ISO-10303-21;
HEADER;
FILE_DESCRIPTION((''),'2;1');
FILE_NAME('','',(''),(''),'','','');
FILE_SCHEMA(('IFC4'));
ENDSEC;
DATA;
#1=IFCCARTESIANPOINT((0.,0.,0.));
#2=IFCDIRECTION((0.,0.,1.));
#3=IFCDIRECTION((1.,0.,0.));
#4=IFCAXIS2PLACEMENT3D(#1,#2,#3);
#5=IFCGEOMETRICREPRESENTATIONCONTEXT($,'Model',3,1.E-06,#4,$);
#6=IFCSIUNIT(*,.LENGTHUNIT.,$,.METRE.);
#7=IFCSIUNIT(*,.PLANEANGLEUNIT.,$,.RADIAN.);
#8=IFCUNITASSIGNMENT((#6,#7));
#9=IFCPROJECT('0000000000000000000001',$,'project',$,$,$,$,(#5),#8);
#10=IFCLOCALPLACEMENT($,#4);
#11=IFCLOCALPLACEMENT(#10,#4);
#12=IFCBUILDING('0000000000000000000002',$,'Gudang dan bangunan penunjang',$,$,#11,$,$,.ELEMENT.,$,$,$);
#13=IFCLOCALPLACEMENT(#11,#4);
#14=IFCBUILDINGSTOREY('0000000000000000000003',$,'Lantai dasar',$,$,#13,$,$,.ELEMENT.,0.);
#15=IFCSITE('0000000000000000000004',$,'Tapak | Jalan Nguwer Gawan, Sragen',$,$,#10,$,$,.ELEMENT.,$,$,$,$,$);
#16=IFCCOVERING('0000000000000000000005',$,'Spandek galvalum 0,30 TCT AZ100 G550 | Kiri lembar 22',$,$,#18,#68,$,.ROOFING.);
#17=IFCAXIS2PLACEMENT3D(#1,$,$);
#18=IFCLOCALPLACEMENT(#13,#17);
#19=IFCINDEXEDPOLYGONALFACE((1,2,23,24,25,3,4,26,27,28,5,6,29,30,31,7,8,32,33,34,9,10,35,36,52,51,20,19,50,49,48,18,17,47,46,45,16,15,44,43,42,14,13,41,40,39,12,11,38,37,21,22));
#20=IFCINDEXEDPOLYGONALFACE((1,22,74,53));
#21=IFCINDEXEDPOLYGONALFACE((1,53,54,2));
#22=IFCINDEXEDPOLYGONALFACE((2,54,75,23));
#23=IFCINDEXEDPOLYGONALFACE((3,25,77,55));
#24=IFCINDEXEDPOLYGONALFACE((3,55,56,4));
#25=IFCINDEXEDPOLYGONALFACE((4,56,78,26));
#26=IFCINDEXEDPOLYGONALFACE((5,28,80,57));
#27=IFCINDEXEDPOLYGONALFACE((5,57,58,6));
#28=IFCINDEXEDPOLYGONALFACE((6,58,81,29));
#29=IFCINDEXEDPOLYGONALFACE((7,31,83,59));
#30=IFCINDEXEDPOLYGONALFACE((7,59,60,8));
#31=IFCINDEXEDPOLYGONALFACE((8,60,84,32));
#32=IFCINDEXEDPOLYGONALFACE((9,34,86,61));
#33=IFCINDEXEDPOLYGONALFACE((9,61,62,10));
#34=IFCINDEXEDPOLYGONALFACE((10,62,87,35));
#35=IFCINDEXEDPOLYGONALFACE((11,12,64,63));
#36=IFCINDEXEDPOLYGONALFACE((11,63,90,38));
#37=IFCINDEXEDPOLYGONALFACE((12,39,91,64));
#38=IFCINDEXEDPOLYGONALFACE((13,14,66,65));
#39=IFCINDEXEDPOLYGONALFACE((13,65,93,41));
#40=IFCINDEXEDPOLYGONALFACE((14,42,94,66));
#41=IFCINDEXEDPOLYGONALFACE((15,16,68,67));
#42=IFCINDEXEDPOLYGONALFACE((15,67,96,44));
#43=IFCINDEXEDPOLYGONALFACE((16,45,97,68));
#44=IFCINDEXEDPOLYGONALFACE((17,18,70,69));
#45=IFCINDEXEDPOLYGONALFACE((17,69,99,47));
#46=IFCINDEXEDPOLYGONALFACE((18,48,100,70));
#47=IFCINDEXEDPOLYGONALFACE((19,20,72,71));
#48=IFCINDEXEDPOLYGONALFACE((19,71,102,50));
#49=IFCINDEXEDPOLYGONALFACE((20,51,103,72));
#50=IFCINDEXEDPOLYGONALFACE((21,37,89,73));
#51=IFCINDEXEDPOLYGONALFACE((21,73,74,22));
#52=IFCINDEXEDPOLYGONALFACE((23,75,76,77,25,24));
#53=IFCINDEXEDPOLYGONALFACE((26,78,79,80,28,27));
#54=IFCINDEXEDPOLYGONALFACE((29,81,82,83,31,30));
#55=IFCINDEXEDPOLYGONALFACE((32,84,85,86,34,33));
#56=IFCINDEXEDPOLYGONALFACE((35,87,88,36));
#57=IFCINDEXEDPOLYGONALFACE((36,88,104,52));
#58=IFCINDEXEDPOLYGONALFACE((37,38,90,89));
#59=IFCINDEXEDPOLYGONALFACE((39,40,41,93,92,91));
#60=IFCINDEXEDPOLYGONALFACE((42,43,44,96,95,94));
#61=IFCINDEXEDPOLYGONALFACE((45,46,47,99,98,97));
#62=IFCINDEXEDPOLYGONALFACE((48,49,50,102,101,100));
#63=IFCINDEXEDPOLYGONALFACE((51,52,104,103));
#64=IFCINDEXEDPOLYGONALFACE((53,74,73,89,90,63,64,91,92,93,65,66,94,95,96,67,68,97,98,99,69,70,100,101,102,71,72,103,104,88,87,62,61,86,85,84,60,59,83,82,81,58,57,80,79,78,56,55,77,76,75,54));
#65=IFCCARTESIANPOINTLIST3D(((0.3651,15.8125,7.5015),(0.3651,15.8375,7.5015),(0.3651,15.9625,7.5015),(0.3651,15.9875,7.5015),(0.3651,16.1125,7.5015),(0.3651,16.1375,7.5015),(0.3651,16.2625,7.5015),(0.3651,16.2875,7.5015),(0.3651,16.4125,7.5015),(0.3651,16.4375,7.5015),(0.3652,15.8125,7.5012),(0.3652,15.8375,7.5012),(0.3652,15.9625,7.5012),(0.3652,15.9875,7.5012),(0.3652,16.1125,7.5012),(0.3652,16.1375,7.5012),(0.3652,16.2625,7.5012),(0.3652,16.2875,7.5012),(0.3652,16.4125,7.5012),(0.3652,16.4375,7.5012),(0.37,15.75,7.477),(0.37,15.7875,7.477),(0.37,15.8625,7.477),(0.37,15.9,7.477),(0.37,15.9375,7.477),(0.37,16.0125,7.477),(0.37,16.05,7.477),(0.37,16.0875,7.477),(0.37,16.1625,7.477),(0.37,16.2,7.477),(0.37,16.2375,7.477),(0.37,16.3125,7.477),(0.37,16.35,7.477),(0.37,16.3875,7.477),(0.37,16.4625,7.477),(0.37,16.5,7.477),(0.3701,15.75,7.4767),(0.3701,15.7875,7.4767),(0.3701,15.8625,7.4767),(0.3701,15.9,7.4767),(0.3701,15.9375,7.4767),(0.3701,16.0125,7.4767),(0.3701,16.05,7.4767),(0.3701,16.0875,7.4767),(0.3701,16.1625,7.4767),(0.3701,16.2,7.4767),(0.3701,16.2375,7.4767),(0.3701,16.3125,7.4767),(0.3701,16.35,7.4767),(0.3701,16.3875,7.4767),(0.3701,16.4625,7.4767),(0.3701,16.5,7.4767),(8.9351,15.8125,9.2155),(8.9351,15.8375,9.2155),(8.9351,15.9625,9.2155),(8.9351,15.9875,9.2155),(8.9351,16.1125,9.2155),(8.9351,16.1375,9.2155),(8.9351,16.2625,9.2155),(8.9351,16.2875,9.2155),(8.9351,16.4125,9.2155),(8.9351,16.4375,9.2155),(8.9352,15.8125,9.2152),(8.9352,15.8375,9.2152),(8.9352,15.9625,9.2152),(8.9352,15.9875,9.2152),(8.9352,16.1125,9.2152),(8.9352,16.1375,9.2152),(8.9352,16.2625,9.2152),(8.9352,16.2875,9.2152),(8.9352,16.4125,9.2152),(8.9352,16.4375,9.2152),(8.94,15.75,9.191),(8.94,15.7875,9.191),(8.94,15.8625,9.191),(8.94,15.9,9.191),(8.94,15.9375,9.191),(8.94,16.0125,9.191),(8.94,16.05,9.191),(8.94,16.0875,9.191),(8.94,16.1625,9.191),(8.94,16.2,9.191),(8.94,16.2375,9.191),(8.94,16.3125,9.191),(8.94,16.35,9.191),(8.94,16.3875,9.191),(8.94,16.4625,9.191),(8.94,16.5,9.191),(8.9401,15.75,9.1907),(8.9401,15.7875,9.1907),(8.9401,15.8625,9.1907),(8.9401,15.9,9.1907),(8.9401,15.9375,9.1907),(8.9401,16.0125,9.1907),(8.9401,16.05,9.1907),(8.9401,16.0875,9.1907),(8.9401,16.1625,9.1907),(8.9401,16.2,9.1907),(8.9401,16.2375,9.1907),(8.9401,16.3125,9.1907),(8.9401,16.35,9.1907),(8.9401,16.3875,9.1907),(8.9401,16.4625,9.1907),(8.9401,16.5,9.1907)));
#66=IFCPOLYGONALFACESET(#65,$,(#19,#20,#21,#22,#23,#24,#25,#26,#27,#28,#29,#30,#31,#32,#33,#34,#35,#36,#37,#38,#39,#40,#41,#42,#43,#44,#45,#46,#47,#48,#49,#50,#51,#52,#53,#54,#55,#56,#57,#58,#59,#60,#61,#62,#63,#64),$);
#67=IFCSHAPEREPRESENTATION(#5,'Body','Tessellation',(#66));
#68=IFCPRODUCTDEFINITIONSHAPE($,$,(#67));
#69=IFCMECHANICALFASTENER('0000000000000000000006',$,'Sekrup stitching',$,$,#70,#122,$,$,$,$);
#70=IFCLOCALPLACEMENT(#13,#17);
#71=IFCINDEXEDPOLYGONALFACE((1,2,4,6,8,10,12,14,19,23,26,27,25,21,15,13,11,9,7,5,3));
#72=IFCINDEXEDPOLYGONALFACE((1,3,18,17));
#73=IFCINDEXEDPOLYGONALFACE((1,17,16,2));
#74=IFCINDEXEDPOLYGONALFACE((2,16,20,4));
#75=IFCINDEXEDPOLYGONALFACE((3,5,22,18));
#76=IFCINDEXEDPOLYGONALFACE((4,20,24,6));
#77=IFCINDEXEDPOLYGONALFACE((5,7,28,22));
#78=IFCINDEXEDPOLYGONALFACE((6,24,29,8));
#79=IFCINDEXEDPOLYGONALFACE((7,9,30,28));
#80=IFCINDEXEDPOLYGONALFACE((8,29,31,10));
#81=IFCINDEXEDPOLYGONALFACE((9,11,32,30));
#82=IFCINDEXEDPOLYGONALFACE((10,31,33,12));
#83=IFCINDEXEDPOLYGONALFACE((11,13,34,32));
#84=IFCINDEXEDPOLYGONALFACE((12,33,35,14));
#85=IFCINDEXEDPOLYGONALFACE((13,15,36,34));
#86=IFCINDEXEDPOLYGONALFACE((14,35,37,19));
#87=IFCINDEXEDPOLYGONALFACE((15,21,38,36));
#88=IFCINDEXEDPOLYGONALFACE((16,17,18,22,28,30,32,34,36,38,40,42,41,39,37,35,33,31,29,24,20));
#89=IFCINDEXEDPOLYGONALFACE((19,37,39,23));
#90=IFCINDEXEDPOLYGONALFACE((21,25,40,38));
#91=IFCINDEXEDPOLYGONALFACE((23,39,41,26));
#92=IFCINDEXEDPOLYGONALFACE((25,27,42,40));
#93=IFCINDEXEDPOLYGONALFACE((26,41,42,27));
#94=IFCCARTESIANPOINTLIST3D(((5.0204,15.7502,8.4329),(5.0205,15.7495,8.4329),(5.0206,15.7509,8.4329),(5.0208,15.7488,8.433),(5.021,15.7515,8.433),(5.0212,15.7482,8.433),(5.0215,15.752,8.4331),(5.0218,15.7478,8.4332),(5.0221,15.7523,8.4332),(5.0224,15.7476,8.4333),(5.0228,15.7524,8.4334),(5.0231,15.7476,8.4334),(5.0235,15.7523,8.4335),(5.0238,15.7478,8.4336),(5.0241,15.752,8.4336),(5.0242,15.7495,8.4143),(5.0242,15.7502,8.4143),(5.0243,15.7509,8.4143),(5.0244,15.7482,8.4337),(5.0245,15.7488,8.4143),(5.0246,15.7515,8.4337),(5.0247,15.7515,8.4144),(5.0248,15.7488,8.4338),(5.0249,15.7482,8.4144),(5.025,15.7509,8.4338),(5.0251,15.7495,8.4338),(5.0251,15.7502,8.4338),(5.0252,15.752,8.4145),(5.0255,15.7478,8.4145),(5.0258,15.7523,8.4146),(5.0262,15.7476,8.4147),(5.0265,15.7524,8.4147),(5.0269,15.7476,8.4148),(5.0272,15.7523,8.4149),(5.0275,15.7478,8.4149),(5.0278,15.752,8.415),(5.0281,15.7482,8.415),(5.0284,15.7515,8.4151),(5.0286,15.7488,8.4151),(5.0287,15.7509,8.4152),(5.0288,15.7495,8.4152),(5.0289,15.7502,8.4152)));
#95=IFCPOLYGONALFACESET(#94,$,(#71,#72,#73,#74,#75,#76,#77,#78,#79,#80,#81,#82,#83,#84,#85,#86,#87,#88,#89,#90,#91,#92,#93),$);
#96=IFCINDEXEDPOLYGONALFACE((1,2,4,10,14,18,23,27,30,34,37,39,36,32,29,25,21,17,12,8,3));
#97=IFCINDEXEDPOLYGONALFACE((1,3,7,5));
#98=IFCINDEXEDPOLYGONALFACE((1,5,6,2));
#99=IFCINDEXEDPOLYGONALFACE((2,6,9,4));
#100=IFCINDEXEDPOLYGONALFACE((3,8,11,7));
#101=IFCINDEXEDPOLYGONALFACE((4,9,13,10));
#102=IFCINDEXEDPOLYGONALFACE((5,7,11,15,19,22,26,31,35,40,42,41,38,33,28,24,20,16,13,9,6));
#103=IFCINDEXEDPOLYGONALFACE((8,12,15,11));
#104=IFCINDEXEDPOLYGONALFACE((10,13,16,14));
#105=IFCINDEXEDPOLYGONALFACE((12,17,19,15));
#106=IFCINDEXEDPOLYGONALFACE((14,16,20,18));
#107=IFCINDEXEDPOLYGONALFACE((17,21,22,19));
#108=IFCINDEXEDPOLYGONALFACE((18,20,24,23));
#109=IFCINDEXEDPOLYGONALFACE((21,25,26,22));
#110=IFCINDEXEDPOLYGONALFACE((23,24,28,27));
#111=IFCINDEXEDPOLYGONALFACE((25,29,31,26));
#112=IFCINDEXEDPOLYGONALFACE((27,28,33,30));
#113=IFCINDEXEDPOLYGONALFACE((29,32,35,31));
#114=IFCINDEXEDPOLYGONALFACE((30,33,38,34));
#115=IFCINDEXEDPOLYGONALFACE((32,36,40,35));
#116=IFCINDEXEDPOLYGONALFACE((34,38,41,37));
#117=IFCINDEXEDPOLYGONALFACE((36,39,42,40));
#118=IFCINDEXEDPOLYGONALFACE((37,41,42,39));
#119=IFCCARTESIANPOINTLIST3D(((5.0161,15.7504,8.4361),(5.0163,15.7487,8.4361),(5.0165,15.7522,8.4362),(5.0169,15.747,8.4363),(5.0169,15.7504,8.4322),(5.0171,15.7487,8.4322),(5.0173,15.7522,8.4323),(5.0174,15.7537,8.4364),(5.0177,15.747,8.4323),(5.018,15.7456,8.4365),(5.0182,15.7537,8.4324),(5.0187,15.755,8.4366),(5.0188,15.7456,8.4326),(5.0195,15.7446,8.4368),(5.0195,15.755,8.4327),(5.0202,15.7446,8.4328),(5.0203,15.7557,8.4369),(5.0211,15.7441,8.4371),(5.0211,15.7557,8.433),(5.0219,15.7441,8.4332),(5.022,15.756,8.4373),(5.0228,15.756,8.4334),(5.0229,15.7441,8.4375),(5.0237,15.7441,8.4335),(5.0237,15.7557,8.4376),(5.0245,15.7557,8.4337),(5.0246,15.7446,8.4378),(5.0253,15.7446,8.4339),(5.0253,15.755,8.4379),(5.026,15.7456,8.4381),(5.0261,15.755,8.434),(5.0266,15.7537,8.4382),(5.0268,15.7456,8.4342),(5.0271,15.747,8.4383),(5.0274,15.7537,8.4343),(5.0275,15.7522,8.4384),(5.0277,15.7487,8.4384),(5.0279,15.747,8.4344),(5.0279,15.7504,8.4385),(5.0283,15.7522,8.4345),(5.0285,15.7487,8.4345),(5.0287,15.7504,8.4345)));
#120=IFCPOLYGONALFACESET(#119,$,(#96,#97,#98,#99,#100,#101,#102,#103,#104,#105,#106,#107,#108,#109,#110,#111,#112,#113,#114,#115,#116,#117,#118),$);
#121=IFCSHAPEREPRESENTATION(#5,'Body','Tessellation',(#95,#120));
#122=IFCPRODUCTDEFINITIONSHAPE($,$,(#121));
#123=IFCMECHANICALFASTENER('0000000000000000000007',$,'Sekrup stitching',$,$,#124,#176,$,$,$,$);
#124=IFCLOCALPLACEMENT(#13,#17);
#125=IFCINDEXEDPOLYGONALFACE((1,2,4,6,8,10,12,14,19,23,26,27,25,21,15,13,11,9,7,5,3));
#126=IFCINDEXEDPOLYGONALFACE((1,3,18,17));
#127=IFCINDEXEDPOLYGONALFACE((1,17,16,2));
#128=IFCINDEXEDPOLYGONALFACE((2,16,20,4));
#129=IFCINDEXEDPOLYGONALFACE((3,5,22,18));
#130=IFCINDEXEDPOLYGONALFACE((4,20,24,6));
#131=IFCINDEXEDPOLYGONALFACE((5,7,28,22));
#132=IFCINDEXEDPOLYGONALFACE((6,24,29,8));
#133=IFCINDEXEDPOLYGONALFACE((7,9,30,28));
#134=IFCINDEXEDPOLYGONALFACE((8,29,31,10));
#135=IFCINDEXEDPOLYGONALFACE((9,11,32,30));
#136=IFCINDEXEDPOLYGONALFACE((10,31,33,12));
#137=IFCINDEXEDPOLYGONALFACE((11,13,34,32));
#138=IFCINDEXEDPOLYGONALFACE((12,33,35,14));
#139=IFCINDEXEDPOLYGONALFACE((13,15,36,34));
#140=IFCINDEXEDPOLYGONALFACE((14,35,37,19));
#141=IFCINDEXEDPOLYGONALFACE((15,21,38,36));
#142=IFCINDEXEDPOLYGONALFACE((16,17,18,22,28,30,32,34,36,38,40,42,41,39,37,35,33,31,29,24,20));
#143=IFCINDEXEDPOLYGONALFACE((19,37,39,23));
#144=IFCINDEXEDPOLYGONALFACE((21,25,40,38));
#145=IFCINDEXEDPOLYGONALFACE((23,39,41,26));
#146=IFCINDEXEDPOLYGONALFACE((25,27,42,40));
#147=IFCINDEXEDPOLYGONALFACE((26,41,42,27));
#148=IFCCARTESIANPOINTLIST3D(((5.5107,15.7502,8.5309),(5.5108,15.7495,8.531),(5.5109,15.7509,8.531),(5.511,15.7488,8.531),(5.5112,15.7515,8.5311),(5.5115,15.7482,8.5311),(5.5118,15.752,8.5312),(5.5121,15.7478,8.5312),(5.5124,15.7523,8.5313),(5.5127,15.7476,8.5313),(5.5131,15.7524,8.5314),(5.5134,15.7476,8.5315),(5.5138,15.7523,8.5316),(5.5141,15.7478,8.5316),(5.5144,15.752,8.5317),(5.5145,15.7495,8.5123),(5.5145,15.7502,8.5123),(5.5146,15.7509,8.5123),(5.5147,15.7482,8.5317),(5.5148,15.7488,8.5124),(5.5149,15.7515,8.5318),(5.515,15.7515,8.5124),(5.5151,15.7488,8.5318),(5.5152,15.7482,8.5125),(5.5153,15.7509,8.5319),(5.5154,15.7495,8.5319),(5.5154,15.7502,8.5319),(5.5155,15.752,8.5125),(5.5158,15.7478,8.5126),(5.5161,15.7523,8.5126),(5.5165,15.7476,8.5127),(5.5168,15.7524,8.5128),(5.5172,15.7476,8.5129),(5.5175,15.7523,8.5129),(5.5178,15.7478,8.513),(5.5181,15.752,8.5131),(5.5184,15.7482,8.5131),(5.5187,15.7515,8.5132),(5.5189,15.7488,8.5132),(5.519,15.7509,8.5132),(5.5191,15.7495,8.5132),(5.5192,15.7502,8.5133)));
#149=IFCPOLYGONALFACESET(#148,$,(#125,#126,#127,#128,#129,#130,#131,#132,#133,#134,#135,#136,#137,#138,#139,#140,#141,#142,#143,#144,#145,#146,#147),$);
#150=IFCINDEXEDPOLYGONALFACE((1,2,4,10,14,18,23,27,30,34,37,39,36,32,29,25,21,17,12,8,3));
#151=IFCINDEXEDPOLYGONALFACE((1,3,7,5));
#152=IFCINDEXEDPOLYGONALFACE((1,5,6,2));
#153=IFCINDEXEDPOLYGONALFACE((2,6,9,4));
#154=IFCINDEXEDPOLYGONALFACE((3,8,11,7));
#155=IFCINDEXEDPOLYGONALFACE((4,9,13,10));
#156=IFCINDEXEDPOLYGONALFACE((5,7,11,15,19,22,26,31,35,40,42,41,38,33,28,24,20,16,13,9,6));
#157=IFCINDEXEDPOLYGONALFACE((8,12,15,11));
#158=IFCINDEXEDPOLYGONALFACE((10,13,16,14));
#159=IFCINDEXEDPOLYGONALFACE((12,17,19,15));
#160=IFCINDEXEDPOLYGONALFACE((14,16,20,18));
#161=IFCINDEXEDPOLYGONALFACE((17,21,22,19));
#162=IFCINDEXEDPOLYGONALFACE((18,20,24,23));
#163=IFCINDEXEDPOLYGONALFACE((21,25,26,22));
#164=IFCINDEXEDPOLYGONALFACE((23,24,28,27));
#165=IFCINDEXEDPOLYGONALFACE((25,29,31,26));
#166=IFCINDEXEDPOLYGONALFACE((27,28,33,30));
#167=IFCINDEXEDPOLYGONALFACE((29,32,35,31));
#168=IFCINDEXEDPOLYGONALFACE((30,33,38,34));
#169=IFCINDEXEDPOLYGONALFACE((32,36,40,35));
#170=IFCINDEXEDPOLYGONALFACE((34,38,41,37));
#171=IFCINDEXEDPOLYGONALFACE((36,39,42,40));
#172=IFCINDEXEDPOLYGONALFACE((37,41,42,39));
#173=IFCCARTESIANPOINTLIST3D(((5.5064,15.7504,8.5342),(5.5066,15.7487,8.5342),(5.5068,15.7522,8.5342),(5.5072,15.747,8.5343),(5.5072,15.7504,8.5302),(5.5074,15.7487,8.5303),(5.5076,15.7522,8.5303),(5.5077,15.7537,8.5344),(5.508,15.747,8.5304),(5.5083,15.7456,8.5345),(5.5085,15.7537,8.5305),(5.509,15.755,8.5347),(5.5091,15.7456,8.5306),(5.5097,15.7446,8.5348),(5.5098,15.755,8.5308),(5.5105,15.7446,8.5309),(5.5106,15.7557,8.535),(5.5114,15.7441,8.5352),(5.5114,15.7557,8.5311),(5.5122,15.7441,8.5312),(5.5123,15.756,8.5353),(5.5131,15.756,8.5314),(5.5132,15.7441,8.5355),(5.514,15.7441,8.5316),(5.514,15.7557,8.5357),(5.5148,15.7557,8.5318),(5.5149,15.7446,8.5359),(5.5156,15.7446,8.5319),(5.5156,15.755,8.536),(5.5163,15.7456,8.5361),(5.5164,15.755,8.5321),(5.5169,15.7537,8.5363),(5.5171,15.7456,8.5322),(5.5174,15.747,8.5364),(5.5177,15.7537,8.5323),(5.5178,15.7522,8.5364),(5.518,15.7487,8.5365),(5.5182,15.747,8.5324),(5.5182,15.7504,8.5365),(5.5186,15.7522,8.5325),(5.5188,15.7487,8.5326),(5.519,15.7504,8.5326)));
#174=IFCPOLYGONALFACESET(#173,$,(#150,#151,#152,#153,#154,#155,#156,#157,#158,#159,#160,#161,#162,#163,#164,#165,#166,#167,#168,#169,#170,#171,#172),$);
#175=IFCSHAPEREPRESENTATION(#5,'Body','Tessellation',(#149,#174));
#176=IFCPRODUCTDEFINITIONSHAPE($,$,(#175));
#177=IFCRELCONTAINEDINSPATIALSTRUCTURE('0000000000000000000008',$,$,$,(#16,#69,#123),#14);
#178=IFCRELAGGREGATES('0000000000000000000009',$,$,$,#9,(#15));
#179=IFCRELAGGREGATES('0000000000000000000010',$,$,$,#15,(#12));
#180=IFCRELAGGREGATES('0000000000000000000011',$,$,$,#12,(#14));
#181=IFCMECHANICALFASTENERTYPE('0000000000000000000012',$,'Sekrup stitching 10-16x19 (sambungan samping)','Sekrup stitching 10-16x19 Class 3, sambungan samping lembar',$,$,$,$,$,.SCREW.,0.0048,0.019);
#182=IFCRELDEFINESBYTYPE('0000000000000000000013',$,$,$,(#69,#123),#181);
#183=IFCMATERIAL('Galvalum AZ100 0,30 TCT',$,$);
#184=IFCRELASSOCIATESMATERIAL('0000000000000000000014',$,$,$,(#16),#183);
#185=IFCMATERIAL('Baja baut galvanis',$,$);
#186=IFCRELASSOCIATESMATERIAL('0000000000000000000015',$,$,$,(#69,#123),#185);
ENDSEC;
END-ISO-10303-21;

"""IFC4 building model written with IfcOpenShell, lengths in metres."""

from ifc_helpers import new_model, si_unit, frame, origin_with_axes, place, context, project, spatial, polyline, circle, outline, extrude, source, transform, mapped, material, type_object, type_shapes, element, save


model = new_model("IFC4")

# Units and contexts
model_context = context("Model", 3, precision=1e-06, world=origin_with_axes())
ifc_project = project(units=[si_unit("LENGTHUNIT", "METRE"), si_unit("PLANEANGLEUNIT", "RADIAN")], contexts=[model_context])

# Site, building, storey
site_placement = place(None, origin_with_axes())
site = spatial("IfcSite", under=ifc_project, at=site_placement, Name="Tapak | Jalan Nguwer Gawan, Sragen", CompositionType="ELEMENT")
building_placement = place(site_placement, origin_with_axes())
building = spatial("IfcBuilding", under=site, at=building_placement, Name="Gudang dan bangunan penunjang", CompositionType="ELEMENT")
storey_placement = place(building_placement, origin_with_axes())
storey = spatial("IfcBuildingStorey", under=building, at=storey_placement, Name="Lantai dasar", CompositionType="ELEMENT", Elevation=0.0)

# Covering
ifc_material_1 = material(Name="Galvalum AZ100 0,30 TCT")
placement = place(None, origin_with_axes())
element("IfcCovering", 1, at=placement, inside=storey, material=ifc_material_1, Name="Spandek galvalum 0,30 TCT AZ100 G550 | Kiri lembar 22", PredefinedType="ROOFING", context=model_context, shape_type="SweptSolid", body=[
    extrude(outline(polyline([(0.0, 0.0), (0.0375, 0.0), (0.0625, 0.025), (0.0875, 0.025), (0.1125, 0.0), (0.15, 0.0), (0.1875, 0.0), (0.2125, 0.025), (0.2375, 0.025), (0.2625, 0.0), (0.3, 0.0), (0.3375, 0.0), (0.3625, 0.025), (0.3875, 0.025), (0.4125, 0.0), (0.45, 0.0), (0.4875, 0.0), (0.5125, 0.025), (0.5375, 0.025), (0.5625, 0.0), (0.6, 0.0), (0.6375, 0.0), (0.6625, 0.025), (0.6875, 0.025), (0.7125, 0.0), (0.75, 0.0), (0.75, -0.0003), (0.7125, -0.0003), (0.6875, 0.0247), (0.6625, 0.0247), (0.6375, -0.0003), (0.6, -0.0003), (0.5625, -0.0003), (0.5375, 0.0247), (0.5125, 0.0247), (0.4875, -0.0003), (0.45, -0.0003), (0.4125, -0.0003), (0.3875, 0.0247), (0.3625, 0.0247), (0.3375, -0.0003), (0.3, -0.0003), (0.2625, -0.0003), (0.2375, 0.0247), (0.2125, 0.0247), (0.1875, -0.0003), (0.15, -0.0003), (0.1125, -0.0003), (0.0875, 0.0247), (0.0625, 0.0247), (0.0375, -0.0003), (0.0, -0.0003), (0.0, 0.0)])), frame((0.37, 15.75, 7.477), z_axis=(0.980581, 0.0, 0.196116), x_axis=(0.0, 1.0, 0.0)), (0.0, 0.0, 1.0), 8.7397),
])

# Mechanical fasteners
ifc_material_2 = material(Name="Baja baut galvanis")
mechanical_fastener_type_1 = type_object("IfcMechanicalFastenerType", Name="Sekrup stitching 10-16x19 (sambungan samping)", Description="Sekrup stitching 10-16x19 Class 3, sambungan samping lembar", NominalDiameter=0.0048, NominalLength=0.019, PredefinedType="SCREW")
shared_shape_1 = source(origin_with_axes(), model_context, "Body", "SweptSolid", [
    extrude(circle(Radius=0.0024), origin_with_axes(), (0.0, 0.0, 1.0), 0.019),
    extrude(circle(Radius=0.006), frame((0.0, 0.0, -0.004), z_axis=(0.0, 0.0, 1.0), x_axis=(1.0, 0.0, 0.0)), (0.0, 0.0, 1.0), 0.004),
])
type_shapes(mechanical_fastener_type_1, [shared_shape_1])
element("IfcMechanicalFastener", 2, at=placement, inside=storey, type_object=mechanical_fastener_type_1, material=ifc_material_2, Name="Sekrup stitching", context=model_context, shape_type="MappedRepresentation", body=[
    mapped(shared_shape_1, transform((5.0228, 15.75, 8.4334), x_axis=(0.0, 1.0, 0.0), y_axis=(0.980581, 0.0, 0.196116), z_axis=(0.196116, 0.0, -0.980581), scale=1.0)),
])
element("IfcMechanicalFastener", 3, at=placement, inside=storey, type_object=mechanical_fastener_type_1, material=ifc_material_2, Name="Sekrup stitching", context=model_context, shape_type="MappedRepresentation", body=[
    mapped(shared_shape_1, transform((5.5131, 15.75, 8.5314), x_axis=(0.0, 1.0, 0.0), y_axis=(0.980581, 0.0, 0.196116), z_axis=(0.196116, 0.0, -0.980581), scale=1.0)),
])

save(model, "model.ifc")
